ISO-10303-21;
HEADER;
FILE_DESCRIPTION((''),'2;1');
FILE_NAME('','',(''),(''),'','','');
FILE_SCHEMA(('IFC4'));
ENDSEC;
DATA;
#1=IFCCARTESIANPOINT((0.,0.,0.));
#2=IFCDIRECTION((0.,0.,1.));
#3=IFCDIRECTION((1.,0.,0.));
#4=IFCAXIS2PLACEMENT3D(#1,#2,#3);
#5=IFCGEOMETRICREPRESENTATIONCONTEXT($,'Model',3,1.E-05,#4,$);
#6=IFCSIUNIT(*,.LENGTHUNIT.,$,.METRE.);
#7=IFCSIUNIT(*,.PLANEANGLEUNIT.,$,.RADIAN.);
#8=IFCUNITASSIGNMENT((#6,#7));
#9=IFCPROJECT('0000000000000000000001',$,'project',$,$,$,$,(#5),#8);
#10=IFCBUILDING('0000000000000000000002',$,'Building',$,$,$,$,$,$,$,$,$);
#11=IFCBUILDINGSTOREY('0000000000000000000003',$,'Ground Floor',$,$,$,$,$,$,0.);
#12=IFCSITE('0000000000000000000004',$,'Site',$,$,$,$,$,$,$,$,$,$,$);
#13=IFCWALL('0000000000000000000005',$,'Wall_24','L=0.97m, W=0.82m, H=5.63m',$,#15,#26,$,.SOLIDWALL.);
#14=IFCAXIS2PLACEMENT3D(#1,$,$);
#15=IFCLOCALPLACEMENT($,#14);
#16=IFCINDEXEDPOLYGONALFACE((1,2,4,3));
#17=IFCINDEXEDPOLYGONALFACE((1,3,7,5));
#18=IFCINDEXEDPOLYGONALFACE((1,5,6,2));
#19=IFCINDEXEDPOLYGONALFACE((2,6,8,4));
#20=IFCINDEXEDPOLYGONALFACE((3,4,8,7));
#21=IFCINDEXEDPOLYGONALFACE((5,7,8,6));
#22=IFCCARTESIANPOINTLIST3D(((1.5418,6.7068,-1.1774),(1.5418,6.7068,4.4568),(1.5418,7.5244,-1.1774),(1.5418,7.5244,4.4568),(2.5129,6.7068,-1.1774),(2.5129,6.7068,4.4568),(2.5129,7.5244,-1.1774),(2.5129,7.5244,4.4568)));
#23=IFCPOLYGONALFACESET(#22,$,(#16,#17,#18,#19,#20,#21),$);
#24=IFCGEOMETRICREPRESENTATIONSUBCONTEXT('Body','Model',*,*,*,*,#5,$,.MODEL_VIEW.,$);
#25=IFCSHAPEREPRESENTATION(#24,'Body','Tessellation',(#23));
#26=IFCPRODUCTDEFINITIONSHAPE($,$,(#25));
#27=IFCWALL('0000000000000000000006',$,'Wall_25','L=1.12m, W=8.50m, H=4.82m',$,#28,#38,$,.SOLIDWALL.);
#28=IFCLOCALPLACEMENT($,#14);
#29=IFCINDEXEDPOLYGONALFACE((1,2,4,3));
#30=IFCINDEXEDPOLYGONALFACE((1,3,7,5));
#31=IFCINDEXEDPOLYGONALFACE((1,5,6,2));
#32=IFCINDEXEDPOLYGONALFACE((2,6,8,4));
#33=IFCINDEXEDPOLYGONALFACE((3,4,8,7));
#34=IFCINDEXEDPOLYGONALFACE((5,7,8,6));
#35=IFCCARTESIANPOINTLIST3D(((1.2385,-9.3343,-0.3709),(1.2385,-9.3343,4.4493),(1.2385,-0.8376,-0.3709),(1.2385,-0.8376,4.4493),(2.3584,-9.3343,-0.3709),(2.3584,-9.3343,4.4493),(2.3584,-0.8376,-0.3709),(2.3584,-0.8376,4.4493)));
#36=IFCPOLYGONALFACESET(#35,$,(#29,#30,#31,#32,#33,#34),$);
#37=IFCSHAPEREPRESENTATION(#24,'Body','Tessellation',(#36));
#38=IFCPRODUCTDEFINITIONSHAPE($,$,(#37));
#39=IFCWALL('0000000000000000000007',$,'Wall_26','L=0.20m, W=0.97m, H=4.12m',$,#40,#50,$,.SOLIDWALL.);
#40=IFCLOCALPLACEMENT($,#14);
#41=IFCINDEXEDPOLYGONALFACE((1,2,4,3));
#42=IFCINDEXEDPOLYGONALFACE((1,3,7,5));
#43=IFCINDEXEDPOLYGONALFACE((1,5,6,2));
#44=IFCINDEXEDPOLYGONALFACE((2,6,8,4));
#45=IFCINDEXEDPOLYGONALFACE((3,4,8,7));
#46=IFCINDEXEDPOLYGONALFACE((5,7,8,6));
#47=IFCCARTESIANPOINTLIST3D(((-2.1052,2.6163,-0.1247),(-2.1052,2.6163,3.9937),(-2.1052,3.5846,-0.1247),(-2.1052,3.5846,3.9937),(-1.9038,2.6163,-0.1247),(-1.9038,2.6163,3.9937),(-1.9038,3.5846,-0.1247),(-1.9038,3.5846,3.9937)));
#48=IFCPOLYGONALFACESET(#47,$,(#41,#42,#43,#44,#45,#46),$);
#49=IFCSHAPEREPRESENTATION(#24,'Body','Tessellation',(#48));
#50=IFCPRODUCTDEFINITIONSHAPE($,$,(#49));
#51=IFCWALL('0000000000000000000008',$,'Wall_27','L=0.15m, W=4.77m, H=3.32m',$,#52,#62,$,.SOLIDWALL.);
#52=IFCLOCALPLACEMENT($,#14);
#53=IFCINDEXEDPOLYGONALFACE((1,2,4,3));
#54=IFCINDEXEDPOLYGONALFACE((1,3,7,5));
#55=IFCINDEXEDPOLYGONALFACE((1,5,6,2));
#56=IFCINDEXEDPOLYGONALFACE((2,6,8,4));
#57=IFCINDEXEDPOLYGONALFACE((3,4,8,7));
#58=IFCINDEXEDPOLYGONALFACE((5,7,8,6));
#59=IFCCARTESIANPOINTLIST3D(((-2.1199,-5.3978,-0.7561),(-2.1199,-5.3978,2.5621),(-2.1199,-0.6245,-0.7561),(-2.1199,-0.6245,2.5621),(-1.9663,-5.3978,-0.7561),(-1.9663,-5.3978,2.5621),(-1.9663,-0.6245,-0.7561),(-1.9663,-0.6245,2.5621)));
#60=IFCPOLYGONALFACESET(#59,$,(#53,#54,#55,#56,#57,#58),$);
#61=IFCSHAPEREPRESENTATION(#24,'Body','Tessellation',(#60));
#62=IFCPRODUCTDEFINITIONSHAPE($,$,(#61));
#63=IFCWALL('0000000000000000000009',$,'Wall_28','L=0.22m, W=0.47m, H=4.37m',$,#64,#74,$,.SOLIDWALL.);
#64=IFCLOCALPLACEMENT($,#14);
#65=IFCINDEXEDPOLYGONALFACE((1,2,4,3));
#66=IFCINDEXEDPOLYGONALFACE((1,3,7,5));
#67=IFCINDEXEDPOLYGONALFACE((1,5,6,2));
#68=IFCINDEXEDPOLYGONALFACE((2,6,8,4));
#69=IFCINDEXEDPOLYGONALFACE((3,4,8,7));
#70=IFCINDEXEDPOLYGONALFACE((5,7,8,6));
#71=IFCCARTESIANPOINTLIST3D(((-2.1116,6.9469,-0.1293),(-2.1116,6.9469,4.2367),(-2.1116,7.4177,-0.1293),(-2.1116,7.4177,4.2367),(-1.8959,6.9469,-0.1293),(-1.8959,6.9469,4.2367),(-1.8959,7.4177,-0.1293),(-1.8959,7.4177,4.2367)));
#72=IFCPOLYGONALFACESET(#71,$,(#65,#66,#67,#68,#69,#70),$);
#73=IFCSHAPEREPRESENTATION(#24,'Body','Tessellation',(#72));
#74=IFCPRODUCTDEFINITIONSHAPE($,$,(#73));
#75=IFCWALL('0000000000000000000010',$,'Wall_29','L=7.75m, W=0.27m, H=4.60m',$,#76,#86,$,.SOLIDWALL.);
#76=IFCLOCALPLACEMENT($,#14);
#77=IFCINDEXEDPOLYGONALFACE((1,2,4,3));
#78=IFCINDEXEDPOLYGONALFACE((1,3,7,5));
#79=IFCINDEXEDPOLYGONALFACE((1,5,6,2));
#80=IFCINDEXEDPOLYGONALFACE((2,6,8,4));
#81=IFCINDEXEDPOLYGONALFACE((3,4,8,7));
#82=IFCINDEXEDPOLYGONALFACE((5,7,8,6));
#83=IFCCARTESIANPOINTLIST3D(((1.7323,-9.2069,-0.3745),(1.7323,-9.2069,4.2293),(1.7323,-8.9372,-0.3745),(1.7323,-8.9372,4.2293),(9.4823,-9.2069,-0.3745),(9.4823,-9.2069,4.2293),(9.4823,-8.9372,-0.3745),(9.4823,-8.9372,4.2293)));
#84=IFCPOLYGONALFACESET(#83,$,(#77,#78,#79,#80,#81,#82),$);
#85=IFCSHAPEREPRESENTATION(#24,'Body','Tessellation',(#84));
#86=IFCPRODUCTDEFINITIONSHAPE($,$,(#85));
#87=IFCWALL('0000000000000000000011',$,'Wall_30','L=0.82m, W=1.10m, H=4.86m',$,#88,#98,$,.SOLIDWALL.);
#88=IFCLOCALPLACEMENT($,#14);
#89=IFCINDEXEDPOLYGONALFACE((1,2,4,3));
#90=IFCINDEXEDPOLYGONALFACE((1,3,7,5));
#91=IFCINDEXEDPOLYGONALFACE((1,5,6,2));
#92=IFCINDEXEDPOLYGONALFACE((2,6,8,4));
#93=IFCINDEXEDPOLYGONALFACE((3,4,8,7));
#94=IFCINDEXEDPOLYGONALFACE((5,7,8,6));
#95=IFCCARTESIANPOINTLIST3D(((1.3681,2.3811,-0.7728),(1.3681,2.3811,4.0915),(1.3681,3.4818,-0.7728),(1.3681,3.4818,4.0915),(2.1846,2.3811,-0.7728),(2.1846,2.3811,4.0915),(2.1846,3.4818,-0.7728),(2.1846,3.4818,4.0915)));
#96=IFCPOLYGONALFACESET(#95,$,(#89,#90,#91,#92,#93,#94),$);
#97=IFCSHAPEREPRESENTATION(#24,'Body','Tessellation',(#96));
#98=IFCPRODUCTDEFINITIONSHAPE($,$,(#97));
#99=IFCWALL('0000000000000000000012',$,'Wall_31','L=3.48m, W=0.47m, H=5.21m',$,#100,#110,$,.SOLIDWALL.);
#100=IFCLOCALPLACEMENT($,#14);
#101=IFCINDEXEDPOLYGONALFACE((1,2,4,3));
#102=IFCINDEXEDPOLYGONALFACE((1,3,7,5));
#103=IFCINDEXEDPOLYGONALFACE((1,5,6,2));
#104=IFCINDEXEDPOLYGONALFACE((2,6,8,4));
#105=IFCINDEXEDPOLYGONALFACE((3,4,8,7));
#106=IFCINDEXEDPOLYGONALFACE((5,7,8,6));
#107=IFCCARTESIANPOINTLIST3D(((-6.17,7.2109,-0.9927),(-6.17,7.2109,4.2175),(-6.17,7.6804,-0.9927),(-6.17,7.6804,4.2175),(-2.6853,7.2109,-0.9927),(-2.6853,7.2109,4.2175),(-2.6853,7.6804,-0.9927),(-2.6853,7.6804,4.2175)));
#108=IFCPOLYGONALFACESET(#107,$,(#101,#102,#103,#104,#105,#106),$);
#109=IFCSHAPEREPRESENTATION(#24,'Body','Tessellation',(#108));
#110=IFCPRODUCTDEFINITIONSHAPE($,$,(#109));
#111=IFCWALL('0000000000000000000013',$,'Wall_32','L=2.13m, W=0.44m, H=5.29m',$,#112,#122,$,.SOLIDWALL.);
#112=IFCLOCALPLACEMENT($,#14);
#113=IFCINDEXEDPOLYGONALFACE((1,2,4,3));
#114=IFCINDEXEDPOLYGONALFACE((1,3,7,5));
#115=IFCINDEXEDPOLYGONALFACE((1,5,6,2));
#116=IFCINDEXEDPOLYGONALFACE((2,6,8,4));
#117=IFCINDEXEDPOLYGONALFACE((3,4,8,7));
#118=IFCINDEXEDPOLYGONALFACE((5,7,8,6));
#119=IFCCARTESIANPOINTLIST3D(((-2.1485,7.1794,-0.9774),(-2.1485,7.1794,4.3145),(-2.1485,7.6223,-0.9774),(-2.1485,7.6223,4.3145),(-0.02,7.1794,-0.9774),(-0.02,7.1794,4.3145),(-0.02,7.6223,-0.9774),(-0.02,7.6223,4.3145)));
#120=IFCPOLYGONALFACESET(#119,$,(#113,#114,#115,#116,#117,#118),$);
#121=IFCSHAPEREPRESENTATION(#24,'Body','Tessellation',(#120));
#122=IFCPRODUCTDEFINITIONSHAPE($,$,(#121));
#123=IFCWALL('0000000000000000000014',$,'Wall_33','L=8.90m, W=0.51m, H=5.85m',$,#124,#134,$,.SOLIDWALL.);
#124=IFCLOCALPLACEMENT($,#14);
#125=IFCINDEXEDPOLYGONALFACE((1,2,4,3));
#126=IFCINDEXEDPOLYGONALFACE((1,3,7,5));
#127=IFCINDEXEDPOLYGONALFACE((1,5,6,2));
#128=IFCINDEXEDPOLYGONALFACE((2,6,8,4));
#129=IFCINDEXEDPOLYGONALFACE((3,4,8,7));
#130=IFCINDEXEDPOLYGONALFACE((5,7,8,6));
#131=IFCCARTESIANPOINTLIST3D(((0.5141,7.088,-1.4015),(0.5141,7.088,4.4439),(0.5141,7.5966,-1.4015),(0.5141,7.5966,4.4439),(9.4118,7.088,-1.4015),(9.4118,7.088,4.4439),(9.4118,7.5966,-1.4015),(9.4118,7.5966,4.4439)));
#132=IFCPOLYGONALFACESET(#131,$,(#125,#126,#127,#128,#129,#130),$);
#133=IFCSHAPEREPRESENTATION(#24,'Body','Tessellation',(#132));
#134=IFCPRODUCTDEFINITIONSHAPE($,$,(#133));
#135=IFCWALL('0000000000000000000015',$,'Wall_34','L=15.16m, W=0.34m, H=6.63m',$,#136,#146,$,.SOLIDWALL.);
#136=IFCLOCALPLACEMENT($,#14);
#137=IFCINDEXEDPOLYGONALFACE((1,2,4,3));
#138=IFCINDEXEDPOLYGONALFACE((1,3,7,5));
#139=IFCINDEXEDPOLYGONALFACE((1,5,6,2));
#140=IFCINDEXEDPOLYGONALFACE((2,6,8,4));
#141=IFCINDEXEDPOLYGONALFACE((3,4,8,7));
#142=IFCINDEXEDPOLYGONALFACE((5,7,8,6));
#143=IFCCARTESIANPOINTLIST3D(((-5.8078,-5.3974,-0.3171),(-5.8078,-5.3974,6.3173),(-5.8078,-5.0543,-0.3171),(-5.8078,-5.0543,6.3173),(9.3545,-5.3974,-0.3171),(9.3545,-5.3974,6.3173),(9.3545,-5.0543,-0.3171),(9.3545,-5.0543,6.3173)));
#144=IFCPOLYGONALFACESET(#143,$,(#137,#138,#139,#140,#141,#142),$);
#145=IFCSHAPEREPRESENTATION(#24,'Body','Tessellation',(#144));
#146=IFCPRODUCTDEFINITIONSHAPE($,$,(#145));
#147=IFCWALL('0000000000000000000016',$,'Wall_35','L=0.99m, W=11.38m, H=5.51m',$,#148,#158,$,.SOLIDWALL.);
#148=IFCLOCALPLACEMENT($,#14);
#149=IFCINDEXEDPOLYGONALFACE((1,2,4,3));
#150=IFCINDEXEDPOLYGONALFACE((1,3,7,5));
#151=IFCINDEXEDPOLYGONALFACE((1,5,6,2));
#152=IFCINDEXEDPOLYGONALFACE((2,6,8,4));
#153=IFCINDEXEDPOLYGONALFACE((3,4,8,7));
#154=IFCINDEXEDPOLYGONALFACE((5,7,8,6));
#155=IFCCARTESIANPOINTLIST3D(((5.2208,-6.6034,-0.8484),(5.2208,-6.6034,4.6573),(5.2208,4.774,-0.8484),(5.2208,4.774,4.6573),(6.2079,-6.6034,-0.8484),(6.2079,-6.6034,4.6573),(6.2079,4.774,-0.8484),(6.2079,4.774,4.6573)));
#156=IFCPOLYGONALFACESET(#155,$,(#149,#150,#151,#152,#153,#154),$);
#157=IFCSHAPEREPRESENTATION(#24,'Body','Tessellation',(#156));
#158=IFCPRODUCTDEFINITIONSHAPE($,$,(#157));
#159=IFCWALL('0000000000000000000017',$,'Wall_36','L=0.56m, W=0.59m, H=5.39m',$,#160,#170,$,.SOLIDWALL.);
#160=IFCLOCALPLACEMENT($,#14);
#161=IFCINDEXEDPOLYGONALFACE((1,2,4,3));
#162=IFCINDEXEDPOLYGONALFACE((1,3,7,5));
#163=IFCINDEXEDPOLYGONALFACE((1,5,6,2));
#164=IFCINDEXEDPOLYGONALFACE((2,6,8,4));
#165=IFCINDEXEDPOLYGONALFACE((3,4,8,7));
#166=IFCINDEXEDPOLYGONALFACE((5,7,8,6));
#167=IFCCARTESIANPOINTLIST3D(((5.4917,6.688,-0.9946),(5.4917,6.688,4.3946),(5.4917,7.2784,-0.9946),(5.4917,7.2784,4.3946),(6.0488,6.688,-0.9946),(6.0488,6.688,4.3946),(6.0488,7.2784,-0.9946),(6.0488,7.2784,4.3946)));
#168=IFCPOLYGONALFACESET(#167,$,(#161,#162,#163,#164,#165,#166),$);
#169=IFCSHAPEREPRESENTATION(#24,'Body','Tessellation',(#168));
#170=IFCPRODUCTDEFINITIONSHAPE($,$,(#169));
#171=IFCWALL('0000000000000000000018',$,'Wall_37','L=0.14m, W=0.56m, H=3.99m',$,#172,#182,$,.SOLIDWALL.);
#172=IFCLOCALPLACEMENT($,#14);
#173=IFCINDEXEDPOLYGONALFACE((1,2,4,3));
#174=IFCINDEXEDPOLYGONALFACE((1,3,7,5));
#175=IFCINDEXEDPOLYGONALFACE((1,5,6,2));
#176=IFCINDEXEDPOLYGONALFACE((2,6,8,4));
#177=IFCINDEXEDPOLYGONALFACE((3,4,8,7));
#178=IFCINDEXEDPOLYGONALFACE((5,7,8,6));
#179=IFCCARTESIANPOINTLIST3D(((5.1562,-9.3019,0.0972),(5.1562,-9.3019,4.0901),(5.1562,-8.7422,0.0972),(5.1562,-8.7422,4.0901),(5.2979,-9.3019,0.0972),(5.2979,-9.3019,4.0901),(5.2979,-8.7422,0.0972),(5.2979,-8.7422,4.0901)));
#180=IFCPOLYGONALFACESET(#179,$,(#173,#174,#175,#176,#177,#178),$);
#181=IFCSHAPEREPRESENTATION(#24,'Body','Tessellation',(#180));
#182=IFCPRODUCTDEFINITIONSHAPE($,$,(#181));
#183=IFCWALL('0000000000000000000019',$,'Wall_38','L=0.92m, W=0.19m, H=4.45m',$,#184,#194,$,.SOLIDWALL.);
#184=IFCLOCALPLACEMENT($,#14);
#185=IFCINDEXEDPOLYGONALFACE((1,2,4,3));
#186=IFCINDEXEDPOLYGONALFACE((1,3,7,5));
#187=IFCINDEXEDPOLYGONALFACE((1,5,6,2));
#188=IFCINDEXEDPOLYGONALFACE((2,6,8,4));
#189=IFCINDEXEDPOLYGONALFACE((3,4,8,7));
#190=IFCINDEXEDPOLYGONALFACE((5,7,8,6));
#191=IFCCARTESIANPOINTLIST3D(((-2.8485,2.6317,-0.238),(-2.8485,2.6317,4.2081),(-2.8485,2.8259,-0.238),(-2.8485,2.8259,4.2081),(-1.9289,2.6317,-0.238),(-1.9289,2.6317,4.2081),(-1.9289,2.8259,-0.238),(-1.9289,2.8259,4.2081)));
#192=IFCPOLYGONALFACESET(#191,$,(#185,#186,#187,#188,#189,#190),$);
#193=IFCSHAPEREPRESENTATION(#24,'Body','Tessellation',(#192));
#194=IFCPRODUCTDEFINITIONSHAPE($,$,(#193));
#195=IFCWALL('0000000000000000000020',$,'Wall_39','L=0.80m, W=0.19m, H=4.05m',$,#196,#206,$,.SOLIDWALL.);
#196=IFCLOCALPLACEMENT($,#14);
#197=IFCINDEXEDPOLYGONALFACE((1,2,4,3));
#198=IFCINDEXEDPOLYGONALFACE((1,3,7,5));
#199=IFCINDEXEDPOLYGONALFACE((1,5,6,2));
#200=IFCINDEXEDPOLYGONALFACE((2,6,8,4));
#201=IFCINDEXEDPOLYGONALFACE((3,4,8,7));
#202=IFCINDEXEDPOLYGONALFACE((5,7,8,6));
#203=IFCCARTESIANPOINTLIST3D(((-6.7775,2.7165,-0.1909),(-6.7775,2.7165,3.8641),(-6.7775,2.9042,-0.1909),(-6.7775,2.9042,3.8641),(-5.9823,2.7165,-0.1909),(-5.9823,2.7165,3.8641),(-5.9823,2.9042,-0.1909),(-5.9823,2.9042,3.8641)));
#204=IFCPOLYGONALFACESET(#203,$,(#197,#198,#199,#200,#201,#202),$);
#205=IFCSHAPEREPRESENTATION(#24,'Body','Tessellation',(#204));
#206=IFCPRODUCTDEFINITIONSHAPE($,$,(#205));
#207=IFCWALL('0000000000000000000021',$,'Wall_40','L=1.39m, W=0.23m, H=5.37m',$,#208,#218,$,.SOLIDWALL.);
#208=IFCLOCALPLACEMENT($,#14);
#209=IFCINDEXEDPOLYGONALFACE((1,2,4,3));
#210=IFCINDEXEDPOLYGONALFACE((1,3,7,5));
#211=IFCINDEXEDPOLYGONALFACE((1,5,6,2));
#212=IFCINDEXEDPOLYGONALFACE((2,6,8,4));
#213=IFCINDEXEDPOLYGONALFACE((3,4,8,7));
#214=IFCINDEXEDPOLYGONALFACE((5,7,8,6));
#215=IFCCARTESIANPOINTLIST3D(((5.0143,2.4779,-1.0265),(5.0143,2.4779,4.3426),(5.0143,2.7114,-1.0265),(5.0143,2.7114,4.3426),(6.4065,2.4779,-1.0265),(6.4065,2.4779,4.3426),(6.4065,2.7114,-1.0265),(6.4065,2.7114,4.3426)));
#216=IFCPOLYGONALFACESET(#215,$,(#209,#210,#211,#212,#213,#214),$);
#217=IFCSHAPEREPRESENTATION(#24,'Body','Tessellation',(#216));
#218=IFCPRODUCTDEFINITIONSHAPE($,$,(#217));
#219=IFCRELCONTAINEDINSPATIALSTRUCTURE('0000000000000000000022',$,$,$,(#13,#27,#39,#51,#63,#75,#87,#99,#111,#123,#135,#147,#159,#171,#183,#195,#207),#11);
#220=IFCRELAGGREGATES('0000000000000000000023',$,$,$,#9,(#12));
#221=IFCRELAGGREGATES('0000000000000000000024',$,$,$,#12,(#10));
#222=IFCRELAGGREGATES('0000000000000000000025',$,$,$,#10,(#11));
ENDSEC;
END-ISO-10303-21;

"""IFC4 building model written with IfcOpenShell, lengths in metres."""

from ifc_helpers import new_model, si_unit, frame, origin_with_axes, origin_2d, context, subcontext, project, spatial, rectangle, extrude, element, save


model = new_model("IFC4")

# Units and contexts
model_context = context("Model", 3, precision=1e-05, world=origin_with_axes())
body_context = subcontext(model_context, "Body", "Model", "MODEL_VIEW")
ifc_project = project(units=[si_unit("LENGTHUNIT", "METRE"), si_unit("PLANEANGLEUNIT", "RADIAN")], contexts=[model_context])

# Site, building, storey
site = spatial("IfcSite", under=ifc_project, Name="Site")
building = spatial("IfcBuilding", under=site, Name="Building")
storey = spatial("IfcBuildingStorey", under=building, Name="Ground Floor", Elevation=0.0)

# Walls
element("IfcWall", 1, inside=storey, Name="Wall_24", Description="L=0.97m, W=0.82m, H=5.63m", PredefinedType="SOLIDWALL", context=body_context, shape_type="SweptSolid", body=[
    extrude(rectangle(XDim=0.9711, YDim=0.8176, at=origin_2d()), frame((2.0273, 7.1156, -1.1774), z_axis=(0.0, 0.0, 1.0), x_axis=(1.0, 0.0, 0.0)), (0.0, 0.0, 1.0), 5.6342),
])
element("IfcWall", 2, inside=storey, Name="Wall_25", Description="L=1.12m, W=8.50m, H=4.82m", PredefinedType="SOLIDWALL", context=body_context, shape_type="SweptSolid", body=[
    extrude(rectangle(XDim=1.1199, YDim=8.4967, at=origin_2d()), frame((1.7984, -5.086, -0.3709), z_axis=(0.0, 0.0, 1.0), x_axis=(1.0, 0.0, 0.0)), (0.0, 0.0, 1.0), 4.8202),
])
element("IfcWall", 3, inside=storey, Name="Wall_26", Description="L=0.20m, W=0.97m, H=4.12m", PredefinedType="SOLIDWALL", context=body_context, shape_type="SweptSolid", body=[
    extrude(rectangle(XDim=0.2014, YDim=0.9684, at=origin_2d()), frame((-2.0045, 3.1005, -0.1247), z_axis=(0.0, 0.0, 1.0), x_axis=(1.0, 0.0, 0.0)), (0.0, 0.0, 1.0), 4.1184),
])
element("IfcWall", 4, inside=storey, Name="Wall_27", Description="L=0.15m, W=4.77m, H=3.32m", PredefinedType="SOLIDWALL", context=body_context, shape_type="SweptSolid", body=[
    extrude(rectangle(XDim=0.1537, YDim=4.7733, at=origin_2d()), frame((-2.0431, -3.0111, -0.7561), z_axis=(0.0, 0.0, 1.0), x_axis=(1.0, 0.0, 0.0)), (0.0, 0.0, 1.0), 3.3182),
])
element("IfcWall", 5, inside=storey, Name="Wall_28", Description="L=0.22m, W=0.47m, H=4.37m", PredefinedType="SOLIDWALL", context=body_context, shape_type="SweptSolid", body=[
    extrude(rectangle(XDim=0.2157, YDim=0.4708, at=origin_2d()), frame((-2.0037, 7.1823, -0.1293), z_axis=(0.0, 0.0, 1.0), x_axis=(1.0, 0.0, 0.0)), (0.0, 0.0, 1.0), 4.366),
])
element("IfcWall", 6, inside=storey, Name="Wall_29", Description="L=7.75m, W=0.27m, H=4.60m", PredefinedType="SOLIDWALL", context=body_context, shape_type="SweptSolid", body=[
    extrude(rectangle(XDim=7.7499, YDim=0.2697, at=origin_2d()), frame((5.6073, -9.072, -0.3745), z_axis=(0.0, 0.0, 1.0), x_axis=(1.0, 0.0, 0.0)), (0.0, 0.0, 1.0), 4.6038),
])
element("IfcWall", 7, inside=storey, Name="Wall_30", Description="L=0.82m, W=1.10m, H=4.86m", PredefinedType="SOLIDWALL", context=body_context, shape_type="SweptSolid", body=[
    extrude(rectangle(XDim=0.8165, YDim=1.1007, at=origin_2d()), frame((1.7764, 2.9314, -0.7728), z_axis=(0.0, 0.0, 1.0), x_axis=(1.0, 0.0, 0.0)), (0.0, 0.0, 1.0), 4.8643),
])
element("IfcWall", 8, inside=storey, Name="Wall_31", Description="L=3.48m, W=0.47m, H=5.21m", PredefinedType="SOLIDWALL", context=body_context, shape_type="SweptSolid", body=[
    extrude(rectangle(XDim=3.4847, YDim=0.4695, at=origin_2d()), frame((-4.4276, 7.4457, -0.9927), z_axis=(0.0, 0.0, 1.0), x_axis=(1.0, 0.0, 0.0)), (0.0, 0.0, 1.0), 5.2102),
])
element("IfcWall", 9, inside=storey, Name="Wall_32", Description="L=2.13m, W=0.44m, H=5.29m", PredefinedType="SOLIDWALL", context=body_context, shape_type="SweptSolid", body=[
    extrude(rectangle(XDim=2.1285, YDim=0.4429, at=origin_2d()), frame((-1.0842, 7.4009, -0.9774), z_axis=(0.0, 0.0, 1.0), x_axis=(1.0, 0.0, 0.0)), (0.0, 0.0, 1.0), 5.2919),
])
element("IfcWall", 10, inside=storey, Name="Wall_33", Description="L=8.90m, W=0.51m, H=5.85m", PredefinedType="SOLIDWALL", context=body_context, shape_type="SweptSolid", body=[
    extrude(rectangle(XDim=8.8977, YDim=0.5085, at=origin_2d()), frame((4.9629, 7.3423, -1.4015), z_axis=(0.0, 0.0, 1.0), x_axis=(1.0, 0.0, 0.0)), (0.0, 0.0, 1.0), 5.8454),
])
element("IfcWall", 11, inside=storey, Name="Wall_34", Description="L=15.16m, W=0.34m, H=6.63m", PredefinedType="SOLIDWALL", context=body_context, shape_type="SweptSolid", body=[
    extrude(rectangle(XDim=15.1623, YDim=0.3431, at=origin_2d()), frame((1.7733, -5.2258, -0.3171), z_axis=(0.0, 0.0, 1.0), x_axis=(1.0, 0.0, 0.0)), (0.0, 0.0, 1.0), 6.6344),
])
element("IfcWall", 12, inside=storey, Name="Wall_35", Description="L=0.99m, W=11.38m, H=5.51m", PredefinedType="SOLIDWALL", context=body_context, shape_type="SweptSolid", body=[
    extrude(rectangle(XDim=0.9872, YDim=11.3773, at=origin_2d()), frame((5.7144, -0.9147, -0.8484), z_axis=(0.0, 0.0, 1.0), x_axis=(1.0, 0.0, 0.0)), (0.0, 0.0, 1.0), 5.5057),
])
element("IfcWall", 13, inside=storey, Name="Wall_36", Description="L=0.56m, W=0.59m, H=5.39m", PredefinedType="SOLIDWALL", context=body_context, shape_type="SweptSolid", body=[
    extrude(rectangle(XDim=0.557, YDim=0.5904, at=origin_2d()), frame((5.7703, 6.9832, -0.9946), z_axis=(0.0, 0.0, 1.0), x_axis=(1.0, 0.0, 0.0)), (0.0, 0.0, 1.0), 5.3891),
])
element("IfcWall", 14, inside=storey, Name="Wall_37", Description="L=0.14m, W=0.56m, H=3.99m", PredefinedType="SOLIDWALL", context=body_context, shape_type="SweptSolid", body=[
    extrude(rectangle(XDim=0.1417, YDim=0.5597, at=origin_2d()), frame((5.227, -9.0221, 0.0972), z_axis=(0.0, 0.0, 1.0), x_axis=(1.0, 0.0, 0.0)), (0.0, 0.0, 1.0), 3.9929),
])
element("IfcWall", 15, inside=storey, Name="Wall_38", Description="L=0.92m, W=0.19m, H=4.45m", PredefinedType="SOLIDWALL", context=body_context, shape_type="SweptSolid", body=[
    extrude(rectangle(XDim=0.9196, YDim=0.1942, at=origin_2d()), frame((-2.3887, 2.7288, -0.238), z_axis=(0.0, 0.0, 1.0), x_axis=(1.0, 0.0, 0.0)), (0.0, 0.0, 1.0), 4.4461),
])
element("IfcWall", 16, inside=storey, Name="Wall_39", Description="L=0.80m, W=0.19m, H=4.05m", PredefinedType="SOLIDWALL", context=body_context, shape_type="SweptSolid", body=[
    extrude(rectangle(XDim=0.7952, YDim=0.1877, at=origin_2d()), frame((-6.3799, 2.8103, -0.1909), z_axis=(0.0, 0.0, 1.0), x_axis=(1.0, 0.0, 0.0)), (0.0, 0.0, 1.0), 4.055),
])
element("IfcWall", 17, inside=storey, Name="Wall_40", Description="L=1.39m, W=0.23m, H=5.37m", PredefinedType="SOLIDWALL", context=body_context, shape_type="SweptSolid", body=[
    extrude(rectangle(XDim=1.3922, YDim=0.2334, at=origin_2d()), frame((5.7104, 2.5946, -1.0265), z_axis=(0.0, 0.0, 1.0), x_axis=(1.0, 0.0, 0.0)), (0.0, 0.0, 1.0), 5.369),
])

save(model, "model.ifc")
